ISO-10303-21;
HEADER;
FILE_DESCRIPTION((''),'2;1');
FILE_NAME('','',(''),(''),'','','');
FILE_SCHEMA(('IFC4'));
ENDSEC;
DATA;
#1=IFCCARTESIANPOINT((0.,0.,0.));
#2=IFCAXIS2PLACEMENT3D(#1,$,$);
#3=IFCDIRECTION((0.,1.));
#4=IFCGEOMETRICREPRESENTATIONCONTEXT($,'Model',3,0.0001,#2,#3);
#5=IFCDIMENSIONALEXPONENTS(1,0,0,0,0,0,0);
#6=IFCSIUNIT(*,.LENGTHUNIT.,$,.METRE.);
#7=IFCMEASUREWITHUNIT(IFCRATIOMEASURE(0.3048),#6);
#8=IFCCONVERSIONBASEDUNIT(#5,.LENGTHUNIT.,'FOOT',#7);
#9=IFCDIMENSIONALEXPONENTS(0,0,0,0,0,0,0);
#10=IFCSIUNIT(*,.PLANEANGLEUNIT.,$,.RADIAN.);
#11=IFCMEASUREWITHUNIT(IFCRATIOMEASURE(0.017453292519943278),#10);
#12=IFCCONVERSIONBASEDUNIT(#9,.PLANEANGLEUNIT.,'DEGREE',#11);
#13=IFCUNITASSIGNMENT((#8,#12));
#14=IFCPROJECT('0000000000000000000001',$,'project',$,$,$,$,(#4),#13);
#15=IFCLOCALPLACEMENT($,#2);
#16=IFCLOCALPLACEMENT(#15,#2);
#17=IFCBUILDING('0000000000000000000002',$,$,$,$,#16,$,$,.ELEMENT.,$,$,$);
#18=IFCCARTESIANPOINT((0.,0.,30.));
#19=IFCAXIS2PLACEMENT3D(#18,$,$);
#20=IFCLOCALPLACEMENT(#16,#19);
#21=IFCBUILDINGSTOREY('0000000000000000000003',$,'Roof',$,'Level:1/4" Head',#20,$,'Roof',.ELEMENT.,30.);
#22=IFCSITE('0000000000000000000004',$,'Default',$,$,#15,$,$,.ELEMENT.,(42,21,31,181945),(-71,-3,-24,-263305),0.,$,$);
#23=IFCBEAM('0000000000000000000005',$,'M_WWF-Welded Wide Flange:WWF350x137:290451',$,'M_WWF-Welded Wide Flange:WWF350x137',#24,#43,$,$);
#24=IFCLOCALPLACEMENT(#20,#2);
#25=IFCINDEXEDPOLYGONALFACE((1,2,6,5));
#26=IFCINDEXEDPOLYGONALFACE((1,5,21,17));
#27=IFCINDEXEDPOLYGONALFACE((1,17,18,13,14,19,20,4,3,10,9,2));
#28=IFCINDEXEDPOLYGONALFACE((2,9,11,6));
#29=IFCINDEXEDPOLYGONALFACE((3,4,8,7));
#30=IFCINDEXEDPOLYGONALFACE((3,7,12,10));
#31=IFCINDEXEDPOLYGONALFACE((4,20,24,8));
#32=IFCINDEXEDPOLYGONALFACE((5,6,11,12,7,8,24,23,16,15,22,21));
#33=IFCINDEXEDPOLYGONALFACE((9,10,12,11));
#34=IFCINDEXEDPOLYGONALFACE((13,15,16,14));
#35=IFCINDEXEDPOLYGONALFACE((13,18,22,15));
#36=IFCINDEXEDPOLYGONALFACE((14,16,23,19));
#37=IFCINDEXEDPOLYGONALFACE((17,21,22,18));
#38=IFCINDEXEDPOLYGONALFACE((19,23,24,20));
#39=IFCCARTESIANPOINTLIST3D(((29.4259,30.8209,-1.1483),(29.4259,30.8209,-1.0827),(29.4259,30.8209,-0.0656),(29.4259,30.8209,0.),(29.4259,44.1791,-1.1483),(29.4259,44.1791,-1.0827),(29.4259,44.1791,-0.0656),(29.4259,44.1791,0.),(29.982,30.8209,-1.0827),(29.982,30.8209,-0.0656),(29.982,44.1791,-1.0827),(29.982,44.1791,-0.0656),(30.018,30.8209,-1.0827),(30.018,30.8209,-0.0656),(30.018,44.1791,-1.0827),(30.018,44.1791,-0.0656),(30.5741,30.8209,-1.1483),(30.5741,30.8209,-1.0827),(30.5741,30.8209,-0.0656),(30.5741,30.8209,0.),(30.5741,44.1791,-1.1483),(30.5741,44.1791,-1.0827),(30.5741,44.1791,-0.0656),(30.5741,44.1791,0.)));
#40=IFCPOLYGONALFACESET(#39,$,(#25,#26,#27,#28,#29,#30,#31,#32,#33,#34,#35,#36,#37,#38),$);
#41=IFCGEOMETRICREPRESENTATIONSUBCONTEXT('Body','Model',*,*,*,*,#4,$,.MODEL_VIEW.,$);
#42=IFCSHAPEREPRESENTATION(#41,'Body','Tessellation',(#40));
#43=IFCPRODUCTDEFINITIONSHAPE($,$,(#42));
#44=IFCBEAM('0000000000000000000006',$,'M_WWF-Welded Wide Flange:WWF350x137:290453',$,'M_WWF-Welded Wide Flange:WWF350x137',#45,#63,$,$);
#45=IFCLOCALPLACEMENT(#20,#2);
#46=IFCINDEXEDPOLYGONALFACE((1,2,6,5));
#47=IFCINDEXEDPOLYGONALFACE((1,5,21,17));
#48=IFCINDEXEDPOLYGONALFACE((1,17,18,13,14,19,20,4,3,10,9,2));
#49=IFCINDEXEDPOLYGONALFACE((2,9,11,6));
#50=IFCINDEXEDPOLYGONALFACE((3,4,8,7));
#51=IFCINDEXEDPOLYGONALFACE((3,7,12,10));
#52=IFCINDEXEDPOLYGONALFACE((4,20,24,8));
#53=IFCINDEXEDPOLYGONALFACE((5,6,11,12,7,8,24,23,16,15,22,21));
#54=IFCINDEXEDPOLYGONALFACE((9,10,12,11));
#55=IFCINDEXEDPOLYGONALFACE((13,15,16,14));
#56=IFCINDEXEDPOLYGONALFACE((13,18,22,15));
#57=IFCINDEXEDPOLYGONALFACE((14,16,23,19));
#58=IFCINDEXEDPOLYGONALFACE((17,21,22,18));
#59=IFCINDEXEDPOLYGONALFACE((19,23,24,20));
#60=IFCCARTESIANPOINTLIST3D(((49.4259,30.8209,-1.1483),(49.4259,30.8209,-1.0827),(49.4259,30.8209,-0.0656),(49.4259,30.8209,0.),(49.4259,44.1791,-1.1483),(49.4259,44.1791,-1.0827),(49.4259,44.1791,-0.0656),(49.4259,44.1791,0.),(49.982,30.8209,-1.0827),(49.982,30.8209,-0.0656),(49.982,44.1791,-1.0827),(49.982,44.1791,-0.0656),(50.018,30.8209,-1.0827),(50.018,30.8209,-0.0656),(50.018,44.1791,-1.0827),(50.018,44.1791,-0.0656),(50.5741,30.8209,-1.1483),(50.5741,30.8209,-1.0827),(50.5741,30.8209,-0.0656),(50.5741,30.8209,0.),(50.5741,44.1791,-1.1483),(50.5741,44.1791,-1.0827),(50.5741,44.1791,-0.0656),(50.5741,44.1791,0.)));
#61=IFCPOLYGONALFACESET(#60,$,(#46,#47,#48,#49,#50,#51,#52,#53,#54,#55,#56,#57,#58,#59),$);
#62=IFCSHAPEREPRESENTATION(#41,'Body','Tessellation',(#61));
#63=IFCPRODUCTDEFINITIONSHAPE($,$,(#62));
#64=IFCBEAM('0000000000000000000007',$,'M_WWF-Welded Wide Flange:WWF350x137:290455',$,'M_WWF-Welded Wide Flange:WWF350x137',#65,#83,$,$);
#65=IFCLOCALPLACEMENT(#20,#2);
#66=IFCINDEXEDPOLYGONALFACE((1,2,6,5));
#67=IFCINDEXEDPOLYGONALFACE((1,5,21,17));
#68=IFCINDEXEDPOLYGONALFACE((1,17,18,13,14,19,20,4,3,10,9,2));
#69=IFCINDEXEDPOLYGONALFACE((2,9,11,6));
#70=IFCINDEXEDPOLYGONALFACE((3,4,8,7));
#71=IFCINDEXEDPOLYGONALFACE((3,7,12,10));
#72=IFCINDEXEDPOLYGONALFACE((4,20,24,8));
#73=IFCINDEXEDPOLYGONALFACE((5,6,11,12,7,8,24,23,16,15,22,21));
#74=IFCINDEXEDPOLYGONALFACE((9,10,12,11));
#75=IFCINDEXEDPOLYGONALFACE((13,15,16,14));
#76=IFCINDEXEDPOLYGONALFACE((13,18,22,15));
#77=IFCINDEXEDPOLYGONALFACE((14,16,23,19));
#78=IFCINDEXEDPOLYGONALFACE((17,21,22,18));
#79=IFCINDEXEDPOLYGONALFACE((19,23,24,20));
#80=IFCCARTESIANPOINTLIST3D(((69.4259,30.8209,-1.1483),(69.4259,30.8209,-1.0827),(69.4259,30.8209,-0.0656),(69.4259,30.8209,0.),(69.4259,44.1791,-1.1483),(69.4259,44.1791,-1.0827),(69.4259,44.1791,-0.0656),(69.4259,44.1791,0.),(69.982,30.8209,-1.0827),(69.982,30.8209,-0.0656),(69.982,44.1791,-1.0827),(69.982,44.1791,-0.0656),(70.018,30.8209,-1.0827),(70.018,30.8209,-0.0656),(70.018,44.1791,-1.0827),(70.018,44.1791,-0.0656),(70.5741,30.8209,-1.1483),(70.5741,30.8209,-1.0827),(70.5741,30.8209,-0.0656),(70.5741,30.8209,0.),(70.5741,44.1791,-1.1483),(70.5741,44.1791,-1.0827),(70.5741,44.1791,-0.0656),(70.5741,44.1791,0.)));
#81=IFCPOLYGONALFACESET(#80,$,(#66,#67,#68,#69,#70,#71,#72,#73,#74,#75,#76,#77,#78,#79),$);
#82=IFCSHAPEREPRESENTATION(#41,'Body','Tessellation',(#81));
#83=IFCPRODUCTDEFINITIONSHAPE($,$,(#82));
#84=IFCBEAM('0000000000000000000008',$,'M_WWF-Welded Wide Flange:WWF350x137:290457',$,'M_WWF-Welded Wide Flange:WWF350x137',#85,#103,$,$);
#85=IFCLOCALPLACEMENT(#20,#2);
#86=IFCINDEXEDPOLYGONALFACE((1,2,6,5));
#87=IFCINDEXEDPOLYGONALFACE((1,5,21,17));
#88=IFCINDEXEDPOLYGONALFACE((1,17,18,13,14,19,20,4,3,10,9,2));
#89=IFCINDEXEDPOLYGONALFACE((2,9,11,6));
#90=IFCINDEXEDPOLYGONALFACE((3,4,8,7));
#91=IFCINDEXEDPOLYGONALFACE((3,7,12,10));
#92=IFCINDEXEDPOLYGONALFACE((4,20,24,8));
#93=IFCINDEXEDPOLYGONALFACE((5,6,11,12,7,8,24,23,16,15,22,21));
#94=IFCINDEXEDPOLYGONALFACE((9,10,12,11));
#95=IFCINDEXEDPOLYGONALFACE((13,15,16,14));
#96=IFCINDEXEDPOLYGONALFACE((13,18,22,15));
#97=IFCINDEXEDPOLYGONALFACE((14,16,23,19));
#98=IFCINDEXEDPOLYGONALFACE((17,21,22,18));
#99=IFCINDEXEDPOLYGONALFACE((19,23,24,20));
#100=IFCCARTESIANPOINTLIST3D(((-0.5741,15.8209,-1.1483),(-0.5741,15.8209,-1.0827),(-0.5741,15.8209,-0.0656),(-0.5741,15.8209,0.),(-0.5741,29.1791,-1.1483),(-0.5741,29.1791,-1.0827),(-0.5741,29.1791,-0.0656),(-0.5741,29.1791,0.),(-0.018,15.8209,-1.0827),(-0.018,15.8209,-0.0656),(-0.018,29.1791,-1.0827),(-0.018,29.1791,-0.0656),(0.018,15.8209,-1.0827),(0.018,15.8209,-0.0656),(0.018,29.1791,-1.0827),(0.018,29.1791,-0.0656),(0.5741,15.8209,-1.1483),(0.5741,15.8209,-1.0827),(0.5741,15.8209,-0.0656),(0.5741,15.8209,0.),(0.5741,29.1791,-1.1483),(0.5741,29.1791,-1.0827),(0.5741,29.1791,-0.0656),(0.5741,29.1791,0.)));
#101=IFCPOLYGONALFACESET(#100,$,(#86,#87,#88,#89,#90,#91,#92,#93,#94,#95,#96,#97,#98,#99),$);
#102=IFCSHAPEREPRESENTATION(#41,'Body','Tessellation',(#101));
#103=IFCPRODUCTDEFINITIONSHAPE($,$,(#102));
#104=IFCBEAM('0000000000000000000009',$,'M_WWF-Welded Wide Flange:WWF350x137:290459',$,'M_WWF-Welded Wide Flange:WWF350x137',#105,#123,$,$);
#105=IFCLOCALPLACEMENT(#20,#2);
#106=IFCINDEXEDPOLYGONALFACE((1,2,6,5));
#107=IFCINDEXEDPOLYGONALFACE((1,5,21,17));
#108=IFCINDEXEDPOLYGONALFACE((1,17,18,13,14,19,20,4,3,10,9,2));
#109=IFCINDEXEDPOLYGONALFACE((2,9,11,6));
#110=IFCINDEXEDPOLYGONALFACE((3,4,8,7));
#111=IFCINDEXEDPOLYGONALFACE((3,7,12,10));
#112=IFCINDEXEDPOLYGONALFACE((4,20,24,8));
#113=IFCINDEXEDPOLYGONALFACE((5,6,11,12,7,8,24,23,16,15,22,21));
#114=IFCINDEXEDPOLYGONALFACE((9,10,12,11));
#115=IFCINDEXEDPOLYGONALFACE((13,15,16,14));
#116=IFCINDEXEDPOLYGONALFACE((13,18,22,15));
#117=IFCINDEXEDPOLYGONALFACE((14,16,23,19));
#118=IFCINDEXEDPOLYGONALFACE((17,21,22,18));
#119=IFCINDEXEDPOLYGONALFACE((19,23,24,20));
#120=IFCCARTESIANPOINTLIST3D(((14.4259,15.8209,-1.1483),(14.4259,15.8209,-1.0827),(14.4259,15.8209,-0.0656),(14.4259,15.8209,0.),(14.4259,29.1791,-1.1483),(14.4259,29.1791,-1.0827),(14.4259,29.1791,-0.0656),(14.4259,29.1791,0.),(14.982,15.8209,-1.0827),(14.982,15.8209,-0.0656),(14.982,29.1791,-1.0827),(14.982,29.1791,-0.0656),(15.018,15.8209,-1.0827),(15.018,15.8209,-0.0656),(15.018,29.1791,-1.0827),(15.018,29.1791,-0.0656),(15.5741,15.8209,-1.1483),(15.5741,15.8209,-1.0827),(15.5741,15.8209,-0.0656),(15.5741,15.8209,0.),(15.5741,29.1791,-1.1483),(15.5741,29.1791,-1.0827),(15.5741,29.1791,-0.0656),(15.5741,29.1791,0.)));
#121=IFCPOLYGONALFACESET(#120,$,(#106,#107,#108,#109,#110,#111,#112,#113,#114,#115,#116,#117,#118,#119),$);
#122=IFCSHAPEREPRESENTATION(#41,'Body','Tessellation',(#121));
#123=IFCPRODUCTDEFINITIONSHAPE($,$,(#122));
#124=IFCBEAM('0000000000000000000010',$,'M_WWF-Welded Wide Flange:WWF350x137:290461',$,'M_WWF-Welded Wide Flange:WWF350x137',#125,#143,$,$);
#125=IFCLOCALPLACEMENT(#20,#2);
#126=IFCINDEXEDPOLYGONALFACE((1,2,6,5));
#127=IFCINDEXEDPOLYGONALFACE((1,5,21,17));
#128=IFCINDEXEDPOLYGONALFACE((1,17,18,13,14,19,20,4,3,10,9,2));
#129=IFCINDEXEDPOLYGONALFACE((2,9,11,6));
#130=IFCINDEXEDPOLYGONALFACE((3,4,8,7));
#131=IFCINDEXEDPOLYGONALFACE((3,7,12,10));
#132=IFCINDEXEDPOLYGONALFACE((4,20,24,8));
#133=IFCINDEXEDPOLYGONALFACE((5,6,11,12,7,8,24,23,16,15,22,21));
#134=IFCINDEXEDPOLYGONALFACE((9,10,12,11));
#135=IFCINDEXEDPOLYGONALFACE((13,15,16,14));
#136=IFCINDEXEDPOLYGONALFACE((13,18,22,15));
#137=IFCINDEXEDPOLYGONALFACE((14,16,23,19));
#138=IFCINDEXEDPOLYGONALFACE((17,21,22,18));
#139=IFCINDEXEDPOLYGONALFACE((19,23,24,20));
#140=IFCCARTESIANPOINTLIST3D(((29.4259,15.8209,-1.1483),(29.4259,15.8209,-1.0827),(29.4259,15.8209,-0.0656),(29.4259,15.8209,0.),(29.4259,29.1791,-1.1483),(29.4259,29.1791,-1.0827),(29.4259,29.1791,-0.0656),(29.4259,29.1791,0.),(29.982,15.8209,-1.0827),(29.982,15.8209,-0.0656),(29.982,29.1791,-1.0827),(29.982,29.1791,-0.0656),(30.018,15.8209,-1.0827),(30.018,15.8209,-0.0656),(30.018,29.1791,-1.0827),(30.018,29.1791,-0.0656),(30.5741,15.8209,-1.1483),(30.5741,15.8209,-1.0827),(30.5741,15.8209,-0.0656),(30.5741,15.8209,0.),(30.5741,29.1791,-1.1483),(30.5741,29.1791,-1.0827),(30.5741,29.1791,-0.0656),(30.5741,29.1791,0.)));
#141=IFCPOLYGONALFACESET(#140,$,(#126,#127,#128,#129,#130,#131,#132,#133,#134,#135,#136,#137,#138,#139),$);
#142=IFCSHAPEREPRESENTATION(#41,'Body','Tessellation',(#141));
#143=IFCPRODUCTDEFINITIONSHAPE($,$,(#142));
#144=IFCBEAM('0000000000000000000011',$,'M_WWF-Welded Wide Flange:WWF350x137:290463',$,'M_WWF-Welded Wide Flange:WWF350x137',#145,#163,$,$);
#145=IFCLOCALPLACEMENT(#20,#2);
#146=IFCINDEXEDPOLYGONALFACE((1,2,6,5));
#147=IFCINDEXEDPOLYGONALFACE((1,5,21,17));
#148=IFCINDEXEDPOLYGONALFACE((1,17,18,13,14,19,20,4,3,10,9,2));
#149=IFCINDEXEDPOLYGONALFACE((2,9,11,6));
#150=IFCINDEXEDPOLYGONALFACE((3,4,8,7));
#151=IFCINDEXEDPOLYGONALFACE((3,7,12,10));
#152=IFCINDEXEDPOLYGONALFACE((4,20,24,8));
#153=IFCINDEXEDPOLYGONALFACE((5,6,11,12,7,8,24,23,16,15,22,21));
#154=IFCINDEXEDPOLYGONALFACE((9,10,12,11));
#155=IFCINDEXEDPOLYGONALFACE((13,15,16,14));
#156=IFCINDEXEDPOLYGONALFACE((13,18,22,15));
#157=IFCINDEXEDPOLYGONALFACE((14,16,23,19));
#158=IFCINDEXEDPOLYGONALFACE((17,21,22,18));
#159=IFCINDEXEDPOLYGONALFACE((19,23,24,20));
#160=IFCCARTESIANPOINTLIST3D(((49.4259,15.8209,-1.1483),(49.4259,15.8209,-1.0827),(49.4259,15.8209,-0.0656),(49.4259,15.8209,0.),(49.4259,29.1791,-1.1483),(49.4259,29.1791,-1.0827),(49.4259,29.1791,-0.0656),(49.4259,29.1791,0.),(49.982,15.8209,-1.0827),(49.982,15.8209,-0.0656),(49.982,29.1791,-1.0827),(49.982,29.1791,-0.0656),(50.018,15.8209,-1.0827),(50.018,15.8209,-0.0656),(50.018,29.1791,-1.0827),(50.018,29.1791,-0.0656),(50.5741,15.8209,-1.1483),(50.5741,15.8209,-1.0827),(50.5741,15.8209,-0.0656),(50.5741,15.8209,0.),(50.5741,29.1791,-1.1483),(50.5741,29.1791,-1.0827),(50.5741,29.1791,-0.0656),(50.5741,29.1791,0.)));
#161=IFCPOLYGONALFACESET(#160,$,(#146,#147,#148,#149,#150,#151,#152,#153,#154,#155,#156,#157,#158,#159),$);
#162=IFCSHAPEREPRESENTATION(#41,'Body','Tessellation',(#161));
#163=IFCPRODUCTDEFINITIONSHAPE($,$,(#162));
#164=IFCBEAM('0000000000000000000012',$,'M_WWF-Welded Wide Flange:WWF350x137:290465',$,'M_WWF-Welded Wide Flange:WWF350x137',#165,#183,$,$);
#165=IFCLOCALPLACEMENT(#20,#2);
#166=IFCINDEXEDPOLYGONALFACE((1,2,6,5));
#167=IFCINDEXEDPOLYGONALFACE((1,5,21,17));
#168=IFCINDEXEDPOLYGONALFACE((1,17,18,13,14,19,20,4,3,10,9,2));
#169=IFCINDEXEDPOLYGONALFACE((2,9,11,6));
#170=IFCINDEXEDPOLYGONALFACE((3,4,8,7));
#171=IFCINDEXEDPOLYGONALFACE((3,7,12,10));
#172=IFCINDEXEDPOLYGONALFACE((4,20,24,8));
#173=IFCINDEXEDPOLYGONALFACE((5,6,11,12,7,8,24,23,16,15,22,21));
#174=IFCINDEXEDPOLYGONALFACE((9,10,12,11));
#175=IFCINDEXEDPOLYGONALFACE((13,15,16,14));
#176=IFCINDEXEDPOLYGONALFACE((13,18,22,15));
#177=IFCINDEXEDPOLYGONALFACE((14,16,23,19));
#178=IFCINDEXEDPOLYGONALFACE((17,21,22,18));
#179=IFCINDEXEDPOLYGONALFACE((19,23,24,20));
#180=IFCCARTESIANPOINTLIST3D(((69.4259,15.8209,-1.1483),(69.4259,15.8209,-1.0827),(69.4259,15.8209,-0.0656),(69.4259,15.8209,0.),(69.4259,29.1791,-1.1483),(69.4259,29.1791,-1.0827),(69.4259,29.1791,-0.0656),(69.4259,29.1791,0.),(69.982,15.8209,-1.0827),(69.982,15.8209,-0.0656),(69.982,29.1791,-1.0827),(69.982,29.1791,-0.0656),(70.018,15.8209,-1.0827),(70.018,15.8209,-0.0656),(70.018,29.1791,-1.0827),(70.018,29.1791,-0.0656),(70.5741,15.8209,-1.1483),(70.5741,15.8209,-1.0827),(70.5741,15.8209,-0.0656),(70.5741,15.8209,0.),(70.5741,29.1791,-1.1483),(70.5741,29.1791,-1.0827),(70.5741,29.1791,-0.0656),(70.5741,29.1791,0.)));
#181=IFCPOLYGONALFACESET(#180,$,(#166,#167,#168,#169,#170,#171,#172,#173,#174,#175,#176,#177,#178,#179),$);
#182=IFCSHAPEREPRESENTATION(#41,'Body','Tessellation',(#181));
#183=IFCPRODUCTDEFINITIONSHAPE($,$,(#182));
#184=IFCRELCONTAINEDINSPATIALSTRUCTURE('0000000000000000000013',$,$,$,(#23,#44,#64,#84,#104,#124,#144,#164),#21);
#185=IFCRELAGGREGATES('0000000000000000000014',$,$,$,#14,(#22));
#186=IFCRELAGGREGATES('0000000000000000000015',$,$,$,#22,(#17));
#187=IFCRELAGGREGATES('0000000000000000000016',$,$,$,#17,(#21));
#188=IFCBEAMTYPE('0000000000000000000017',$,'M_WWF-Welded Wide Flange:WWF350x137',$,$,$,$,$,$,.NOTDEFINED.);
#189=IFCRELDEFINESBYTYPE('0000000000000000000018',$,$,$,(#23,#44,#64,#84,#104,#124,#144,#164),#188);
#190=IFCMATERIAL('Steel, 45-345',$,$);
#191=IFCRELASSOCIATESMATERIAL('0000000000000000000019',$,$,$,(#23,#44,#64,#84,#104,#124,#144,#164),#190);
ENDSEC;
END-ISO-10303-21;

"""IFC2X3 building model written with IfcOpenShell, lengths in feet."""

from ifc_helpers import new_model, entity, si_unit, converted_unit, direction, frame, frame_2d, origin, place, context, subcontext, project, spatial, i_section, extrude, material, type_object, element, save


model = new_model("IFC2X3")

# Units and contexts
model_context = context("Model", 3, precision=0.0001, world=origin(), true_north=direction((0.0, 1.0)))
body_context = subcontext(model_context, "Body", "Model", "MODEL_VIEW")
ifc_project = project(units=[converted_unit("LENGTHUNIT", "FOOT", entity("IfcRatioMeasure", 0.3048), si_unit("LENGTHUNIT", "METRE"), dimensions=[1, 0, 0, 0, 0, 0, 0]), converted_unit("PLANEANGLEUNIT", "DEGREE", entity("IfcRatioMeasure", 0.017453292519943278), si_unit("PLANEANGLEUNIT", "RADIAN"), dimensions=[0, 0, 0, 0, 0, 0, 0])], contexts=[model_context])

# Site, building, storey
site_placement = place(None, origin())
site = spatial("IfcSite", under=ifc_project, at=site_placement, Name="Default", CompositionType="ELEMENT", RefLatitude=(42, 21, 31, 181945), RefLongitude=(-71, -3, -24, -263305), RefElevation=0.0)
building_placement = place(site_placement, origin())
building = spatial("IfcBuilding", under=site, at=building_placement, CompositionType="ELEMENT")
storey_placement = place(building_placement, frame((0.0, 0.0, 30.0)))
storey = spatial("IfcBuildingStorey", under=building, at=storey_placement, Name="Roof", ObjectType="Level:1/4\" Head", LongName="Roof", CompositionType="ELEMENT", Elevation=30.0)

# Beams
ifc_material = material(Name="Steel, 45-345")
beam_type = type_object("IfcBeamType", Name="M_WWF-Welded Wide Flange:WWF350x137", PredefinedType="NOTDEFINED")
beam_1_placement = place(storey_placement, frame((30.0, 30.0, 0.0), z_axis=(0.0, 0.0, 1.0), x_axis=(0.0, 1.0, 0.0)))
element("IfcBeam", 1, at=beam_1_placement, inside=storey, type_object=beam_type, material=ifc_material, Name="M_WWF-Welded Wide Flange:WWF350x137:290451", ObjectType="M_WWF-Welded Wide Flange:WWF350x137", context=body_context, shape_type="SweptSolid", body=[
    extrude(i_section(OverallWidth=1.1483, OverallDepth=1.1483, WebThickness=0.0361, FlangeThickness=0.0656, at=frame_2d((0.0, 0.0), x_axis=(0.0, 1.0))), frame((0.8209, 0.0, -0.5741), z_axis=(1.0, 0.0, 0.0), x_axis=(0.0, 0.0, -1.0)), (0.0, 0.0, 1.0), 13.3583),
])
beam_2_placement = place(storey_placement, frame((50.0, 30.0, 0.0), z_axis=(0.0, 0.0, 1.0), x_axis=(0.0, 1.0, 0.0)))
element("IfcBeam", 2, at=beam_2_placement, inside=storey, type_object=beam_type, material=ifc_material, Name="M_WWF-Welded Wide Flange:WWF350x137:290453", ObjectType="M_WWF-Welded Wide Flange:WWF350x137", context=body_context, shape_type="SweptSolid", body=[
    extrude(i_section(OverallWidth=1.1483, OverallDepth=1.1483, WebThickness=0.0361, FlangeThickness=0.0656, at=frame_2d((0.0, 0.0), x_axis=(0.0, 1.0))), frame((0.8209, 0.0, -0.5741), z_axis=(1.0, 0.0, 0.0), x_axis=(0.0, 0.0, -1.0)), (0.0, 0.0, 1.0), 13.3583),
])
beam_3_placement = place(storey_placement, frame((70.0, 30.0, 0.0), z_axis=(0.0, 0.0, 1.0), x_axis=(0.0, 1.0, 0.0)))
element("IfcBeam", 3, at=beam_3_placement, inside=storey, type_object=beam_type, material=ifc_material, Name="M_WWF-Welded Wide Flange:WWF350x137:290455", ObjectType="M_WWF-Welded Wide Flange:WWF350x137", context=body_context, shape_type="SweptSolid", body=[
    extrude(i_section(OverallWidth=1.1483, OverallDepth=1.1483, WebThickness=0.0361, FlangeThickness=0.0656, at=frame_2d((0.0, 0.0), x_axis=(0.0, 1.0))), frame((0.8209, 0.0, -0.5741), z_axis=(1.0, 0.0, 0.0), x_axis=(0.0, 0.0, -1.0)), (0.0, 0.0, 1.0), 13.3583),
])
beam_4_placement = place(storey_placement, frame((0.0, 15.0, 0.0), z_axis=(0.0, 0.0, 1.0), x_axis=(0.0, 1.0, 0.0)))
element("IfcBeam", 4, at=beam_4_placement, inside=storey, type_object=beam_type, material=ifc_material, Name="M_WWF-Welded Wide Flange:WWF350x137:290457", ObjectType="M_WWF-Welded Wide Flange:WWF350x137", context=body_context, shape_type="SweptSolid", body=[
    extrude(i_section(OverallWidth=1.1483, OverallDepth=1.1483, WebThickness=0.0361, FlangeThickness=0.0656, at=frame_2d((0.0, 0.0), x_axis=(0.0, 1.0))), frame((0.8209, 0.0, -0.5741), z_axis=(1.0, 0.0, 0.0), x_axis=(0.0, 0.0, -1.0)), (0.0, 0.0, 1.0), 13.3583),
])
beam_5_placement = place(storey_placement, frame((15.0, 15.0, 0.0), z_axis=(0.0, 0.0, 1.0), x_axis=(0.0, 1.0, 0.0)))
element("IfcBeam", 5, at=beam_5_placement, inside=storey, type_object=beam_type, material=ifc_material, Name="M_WWF-Welded Wide Flange:WWF350x137:290459", ObjectType="M_WWF-Welded Wide Flange:WWF350x137", context=body_context, shape_type="SweptSolid", body=[
    extrude(i_section(OverallWidth=1.1483, OverallDepth=1.1483, WebThickness=0.0361, FlangeThickness=0.0656, at=frame_2d((0.0, 0.0), x_axis=(0.0, 1.0))), frame((0.8209, 0.0, -0.5741), z_axis=(1.0, 0.0, 0.0), x_axis=(0.0, 0.0, -1.0)), (0.0, 0.0, 1.0), 13.3583),
])
beam_6_placement = place(storey_placement, frame((30.0, 15.0, 0.0), z_axis=(0.0, 0.0, 1.0), x_axis=(0.0, 1.0, 0.0)))
element("IfcBeam", 6, at=beam_6_placement, inside=storey, type_object=beam_type, material=ifc_material, Name="M_WWF-Welded Wide Flange:WWF350x137:290461", ObjectType="M_WWF-Welded Wide Flange:WWF350x137", context=body_context, shape_type="SweptSolid", body=[
    extrude(i_section(OverallWidth=1.1483, OverallDepth=1.1483, WebThickness=0.0361, FlangeThickness=0.0656, at=frame_2d((0.0, 0.0), x_axis=(0.0, 1.0))), frame((0.8209, 0.0, -0.5741), z_axis=(1.0, 0.0, 0.0), x_axis=(0.0, 0.0, -1.0)), (0.0, 0.0, 1.0), 13.3583),
])
beam_7_placement = place(storey_placement, frame((50.0, 15.0, 0.0), z_axis=(0.0, 0.0, 1.0), x_axis=(0.0, 1.0, 0.0)))
element("IfcBeam", 7, at=beam_7_placement, inside=storey, type_object=beam_type, material=ifc_material, Name="M_WWF-Welded Wide Flange:WWF350x137:290463", ObjectType="M_WWF-Welded Wide Flange:WWF350x137", context=body_context, shape_type="SweptSolid", body=[
    extrude(i_section(OverallWidth=1.1483, OverallDepth=1.1483, WebThickness=0.0361, FlangeThickness=0.0656, at=frame_2d((0.0, 0.0), x_axis=(0.0, 1.0))), frame((0.8209, 0.0, -0.5741), z_axis=(1.0, 0.0, 0.0), x_axis=(0.0, 0.0, -1.0)), (0.0, 0.0, 1.0), 13.3583),
])
beam_8_placement = place(storey_placement, frame((70.0, 15.0, 0.0), z_axis=(0.0, 0.0, 1.0), x_axis=(0.0, 1.0, 0.0)))
element("IfcBeam", 8, at=beam_8_placement, inside=storey, type_object=beam_type, material=ifc_material, Name="M_WWF-Welded Wide Flange:WWF350x137:290465", ObjectType="M_WWF-Welded Wide Flange:WWF350x137", context=body_context, shape_type="SweptSolid", body=[
    extrude(i_section(OverallWidth=1.1483, OverallDepth=1.1483, WebThickness=0.0361, FlangeThickness=0.0656, at=frame_2d((0.0, 0.0), x_axis=(0.0, 1.0))), frame((0.8209, 0.0, -0.5741), z_axis=(1.0, 0.0, 0.0), x_axis=(0.0, 0.0, -1.0)), (0.0, 0.0, 1.0), 13.3583),
])

save(model, "model.ifc")
